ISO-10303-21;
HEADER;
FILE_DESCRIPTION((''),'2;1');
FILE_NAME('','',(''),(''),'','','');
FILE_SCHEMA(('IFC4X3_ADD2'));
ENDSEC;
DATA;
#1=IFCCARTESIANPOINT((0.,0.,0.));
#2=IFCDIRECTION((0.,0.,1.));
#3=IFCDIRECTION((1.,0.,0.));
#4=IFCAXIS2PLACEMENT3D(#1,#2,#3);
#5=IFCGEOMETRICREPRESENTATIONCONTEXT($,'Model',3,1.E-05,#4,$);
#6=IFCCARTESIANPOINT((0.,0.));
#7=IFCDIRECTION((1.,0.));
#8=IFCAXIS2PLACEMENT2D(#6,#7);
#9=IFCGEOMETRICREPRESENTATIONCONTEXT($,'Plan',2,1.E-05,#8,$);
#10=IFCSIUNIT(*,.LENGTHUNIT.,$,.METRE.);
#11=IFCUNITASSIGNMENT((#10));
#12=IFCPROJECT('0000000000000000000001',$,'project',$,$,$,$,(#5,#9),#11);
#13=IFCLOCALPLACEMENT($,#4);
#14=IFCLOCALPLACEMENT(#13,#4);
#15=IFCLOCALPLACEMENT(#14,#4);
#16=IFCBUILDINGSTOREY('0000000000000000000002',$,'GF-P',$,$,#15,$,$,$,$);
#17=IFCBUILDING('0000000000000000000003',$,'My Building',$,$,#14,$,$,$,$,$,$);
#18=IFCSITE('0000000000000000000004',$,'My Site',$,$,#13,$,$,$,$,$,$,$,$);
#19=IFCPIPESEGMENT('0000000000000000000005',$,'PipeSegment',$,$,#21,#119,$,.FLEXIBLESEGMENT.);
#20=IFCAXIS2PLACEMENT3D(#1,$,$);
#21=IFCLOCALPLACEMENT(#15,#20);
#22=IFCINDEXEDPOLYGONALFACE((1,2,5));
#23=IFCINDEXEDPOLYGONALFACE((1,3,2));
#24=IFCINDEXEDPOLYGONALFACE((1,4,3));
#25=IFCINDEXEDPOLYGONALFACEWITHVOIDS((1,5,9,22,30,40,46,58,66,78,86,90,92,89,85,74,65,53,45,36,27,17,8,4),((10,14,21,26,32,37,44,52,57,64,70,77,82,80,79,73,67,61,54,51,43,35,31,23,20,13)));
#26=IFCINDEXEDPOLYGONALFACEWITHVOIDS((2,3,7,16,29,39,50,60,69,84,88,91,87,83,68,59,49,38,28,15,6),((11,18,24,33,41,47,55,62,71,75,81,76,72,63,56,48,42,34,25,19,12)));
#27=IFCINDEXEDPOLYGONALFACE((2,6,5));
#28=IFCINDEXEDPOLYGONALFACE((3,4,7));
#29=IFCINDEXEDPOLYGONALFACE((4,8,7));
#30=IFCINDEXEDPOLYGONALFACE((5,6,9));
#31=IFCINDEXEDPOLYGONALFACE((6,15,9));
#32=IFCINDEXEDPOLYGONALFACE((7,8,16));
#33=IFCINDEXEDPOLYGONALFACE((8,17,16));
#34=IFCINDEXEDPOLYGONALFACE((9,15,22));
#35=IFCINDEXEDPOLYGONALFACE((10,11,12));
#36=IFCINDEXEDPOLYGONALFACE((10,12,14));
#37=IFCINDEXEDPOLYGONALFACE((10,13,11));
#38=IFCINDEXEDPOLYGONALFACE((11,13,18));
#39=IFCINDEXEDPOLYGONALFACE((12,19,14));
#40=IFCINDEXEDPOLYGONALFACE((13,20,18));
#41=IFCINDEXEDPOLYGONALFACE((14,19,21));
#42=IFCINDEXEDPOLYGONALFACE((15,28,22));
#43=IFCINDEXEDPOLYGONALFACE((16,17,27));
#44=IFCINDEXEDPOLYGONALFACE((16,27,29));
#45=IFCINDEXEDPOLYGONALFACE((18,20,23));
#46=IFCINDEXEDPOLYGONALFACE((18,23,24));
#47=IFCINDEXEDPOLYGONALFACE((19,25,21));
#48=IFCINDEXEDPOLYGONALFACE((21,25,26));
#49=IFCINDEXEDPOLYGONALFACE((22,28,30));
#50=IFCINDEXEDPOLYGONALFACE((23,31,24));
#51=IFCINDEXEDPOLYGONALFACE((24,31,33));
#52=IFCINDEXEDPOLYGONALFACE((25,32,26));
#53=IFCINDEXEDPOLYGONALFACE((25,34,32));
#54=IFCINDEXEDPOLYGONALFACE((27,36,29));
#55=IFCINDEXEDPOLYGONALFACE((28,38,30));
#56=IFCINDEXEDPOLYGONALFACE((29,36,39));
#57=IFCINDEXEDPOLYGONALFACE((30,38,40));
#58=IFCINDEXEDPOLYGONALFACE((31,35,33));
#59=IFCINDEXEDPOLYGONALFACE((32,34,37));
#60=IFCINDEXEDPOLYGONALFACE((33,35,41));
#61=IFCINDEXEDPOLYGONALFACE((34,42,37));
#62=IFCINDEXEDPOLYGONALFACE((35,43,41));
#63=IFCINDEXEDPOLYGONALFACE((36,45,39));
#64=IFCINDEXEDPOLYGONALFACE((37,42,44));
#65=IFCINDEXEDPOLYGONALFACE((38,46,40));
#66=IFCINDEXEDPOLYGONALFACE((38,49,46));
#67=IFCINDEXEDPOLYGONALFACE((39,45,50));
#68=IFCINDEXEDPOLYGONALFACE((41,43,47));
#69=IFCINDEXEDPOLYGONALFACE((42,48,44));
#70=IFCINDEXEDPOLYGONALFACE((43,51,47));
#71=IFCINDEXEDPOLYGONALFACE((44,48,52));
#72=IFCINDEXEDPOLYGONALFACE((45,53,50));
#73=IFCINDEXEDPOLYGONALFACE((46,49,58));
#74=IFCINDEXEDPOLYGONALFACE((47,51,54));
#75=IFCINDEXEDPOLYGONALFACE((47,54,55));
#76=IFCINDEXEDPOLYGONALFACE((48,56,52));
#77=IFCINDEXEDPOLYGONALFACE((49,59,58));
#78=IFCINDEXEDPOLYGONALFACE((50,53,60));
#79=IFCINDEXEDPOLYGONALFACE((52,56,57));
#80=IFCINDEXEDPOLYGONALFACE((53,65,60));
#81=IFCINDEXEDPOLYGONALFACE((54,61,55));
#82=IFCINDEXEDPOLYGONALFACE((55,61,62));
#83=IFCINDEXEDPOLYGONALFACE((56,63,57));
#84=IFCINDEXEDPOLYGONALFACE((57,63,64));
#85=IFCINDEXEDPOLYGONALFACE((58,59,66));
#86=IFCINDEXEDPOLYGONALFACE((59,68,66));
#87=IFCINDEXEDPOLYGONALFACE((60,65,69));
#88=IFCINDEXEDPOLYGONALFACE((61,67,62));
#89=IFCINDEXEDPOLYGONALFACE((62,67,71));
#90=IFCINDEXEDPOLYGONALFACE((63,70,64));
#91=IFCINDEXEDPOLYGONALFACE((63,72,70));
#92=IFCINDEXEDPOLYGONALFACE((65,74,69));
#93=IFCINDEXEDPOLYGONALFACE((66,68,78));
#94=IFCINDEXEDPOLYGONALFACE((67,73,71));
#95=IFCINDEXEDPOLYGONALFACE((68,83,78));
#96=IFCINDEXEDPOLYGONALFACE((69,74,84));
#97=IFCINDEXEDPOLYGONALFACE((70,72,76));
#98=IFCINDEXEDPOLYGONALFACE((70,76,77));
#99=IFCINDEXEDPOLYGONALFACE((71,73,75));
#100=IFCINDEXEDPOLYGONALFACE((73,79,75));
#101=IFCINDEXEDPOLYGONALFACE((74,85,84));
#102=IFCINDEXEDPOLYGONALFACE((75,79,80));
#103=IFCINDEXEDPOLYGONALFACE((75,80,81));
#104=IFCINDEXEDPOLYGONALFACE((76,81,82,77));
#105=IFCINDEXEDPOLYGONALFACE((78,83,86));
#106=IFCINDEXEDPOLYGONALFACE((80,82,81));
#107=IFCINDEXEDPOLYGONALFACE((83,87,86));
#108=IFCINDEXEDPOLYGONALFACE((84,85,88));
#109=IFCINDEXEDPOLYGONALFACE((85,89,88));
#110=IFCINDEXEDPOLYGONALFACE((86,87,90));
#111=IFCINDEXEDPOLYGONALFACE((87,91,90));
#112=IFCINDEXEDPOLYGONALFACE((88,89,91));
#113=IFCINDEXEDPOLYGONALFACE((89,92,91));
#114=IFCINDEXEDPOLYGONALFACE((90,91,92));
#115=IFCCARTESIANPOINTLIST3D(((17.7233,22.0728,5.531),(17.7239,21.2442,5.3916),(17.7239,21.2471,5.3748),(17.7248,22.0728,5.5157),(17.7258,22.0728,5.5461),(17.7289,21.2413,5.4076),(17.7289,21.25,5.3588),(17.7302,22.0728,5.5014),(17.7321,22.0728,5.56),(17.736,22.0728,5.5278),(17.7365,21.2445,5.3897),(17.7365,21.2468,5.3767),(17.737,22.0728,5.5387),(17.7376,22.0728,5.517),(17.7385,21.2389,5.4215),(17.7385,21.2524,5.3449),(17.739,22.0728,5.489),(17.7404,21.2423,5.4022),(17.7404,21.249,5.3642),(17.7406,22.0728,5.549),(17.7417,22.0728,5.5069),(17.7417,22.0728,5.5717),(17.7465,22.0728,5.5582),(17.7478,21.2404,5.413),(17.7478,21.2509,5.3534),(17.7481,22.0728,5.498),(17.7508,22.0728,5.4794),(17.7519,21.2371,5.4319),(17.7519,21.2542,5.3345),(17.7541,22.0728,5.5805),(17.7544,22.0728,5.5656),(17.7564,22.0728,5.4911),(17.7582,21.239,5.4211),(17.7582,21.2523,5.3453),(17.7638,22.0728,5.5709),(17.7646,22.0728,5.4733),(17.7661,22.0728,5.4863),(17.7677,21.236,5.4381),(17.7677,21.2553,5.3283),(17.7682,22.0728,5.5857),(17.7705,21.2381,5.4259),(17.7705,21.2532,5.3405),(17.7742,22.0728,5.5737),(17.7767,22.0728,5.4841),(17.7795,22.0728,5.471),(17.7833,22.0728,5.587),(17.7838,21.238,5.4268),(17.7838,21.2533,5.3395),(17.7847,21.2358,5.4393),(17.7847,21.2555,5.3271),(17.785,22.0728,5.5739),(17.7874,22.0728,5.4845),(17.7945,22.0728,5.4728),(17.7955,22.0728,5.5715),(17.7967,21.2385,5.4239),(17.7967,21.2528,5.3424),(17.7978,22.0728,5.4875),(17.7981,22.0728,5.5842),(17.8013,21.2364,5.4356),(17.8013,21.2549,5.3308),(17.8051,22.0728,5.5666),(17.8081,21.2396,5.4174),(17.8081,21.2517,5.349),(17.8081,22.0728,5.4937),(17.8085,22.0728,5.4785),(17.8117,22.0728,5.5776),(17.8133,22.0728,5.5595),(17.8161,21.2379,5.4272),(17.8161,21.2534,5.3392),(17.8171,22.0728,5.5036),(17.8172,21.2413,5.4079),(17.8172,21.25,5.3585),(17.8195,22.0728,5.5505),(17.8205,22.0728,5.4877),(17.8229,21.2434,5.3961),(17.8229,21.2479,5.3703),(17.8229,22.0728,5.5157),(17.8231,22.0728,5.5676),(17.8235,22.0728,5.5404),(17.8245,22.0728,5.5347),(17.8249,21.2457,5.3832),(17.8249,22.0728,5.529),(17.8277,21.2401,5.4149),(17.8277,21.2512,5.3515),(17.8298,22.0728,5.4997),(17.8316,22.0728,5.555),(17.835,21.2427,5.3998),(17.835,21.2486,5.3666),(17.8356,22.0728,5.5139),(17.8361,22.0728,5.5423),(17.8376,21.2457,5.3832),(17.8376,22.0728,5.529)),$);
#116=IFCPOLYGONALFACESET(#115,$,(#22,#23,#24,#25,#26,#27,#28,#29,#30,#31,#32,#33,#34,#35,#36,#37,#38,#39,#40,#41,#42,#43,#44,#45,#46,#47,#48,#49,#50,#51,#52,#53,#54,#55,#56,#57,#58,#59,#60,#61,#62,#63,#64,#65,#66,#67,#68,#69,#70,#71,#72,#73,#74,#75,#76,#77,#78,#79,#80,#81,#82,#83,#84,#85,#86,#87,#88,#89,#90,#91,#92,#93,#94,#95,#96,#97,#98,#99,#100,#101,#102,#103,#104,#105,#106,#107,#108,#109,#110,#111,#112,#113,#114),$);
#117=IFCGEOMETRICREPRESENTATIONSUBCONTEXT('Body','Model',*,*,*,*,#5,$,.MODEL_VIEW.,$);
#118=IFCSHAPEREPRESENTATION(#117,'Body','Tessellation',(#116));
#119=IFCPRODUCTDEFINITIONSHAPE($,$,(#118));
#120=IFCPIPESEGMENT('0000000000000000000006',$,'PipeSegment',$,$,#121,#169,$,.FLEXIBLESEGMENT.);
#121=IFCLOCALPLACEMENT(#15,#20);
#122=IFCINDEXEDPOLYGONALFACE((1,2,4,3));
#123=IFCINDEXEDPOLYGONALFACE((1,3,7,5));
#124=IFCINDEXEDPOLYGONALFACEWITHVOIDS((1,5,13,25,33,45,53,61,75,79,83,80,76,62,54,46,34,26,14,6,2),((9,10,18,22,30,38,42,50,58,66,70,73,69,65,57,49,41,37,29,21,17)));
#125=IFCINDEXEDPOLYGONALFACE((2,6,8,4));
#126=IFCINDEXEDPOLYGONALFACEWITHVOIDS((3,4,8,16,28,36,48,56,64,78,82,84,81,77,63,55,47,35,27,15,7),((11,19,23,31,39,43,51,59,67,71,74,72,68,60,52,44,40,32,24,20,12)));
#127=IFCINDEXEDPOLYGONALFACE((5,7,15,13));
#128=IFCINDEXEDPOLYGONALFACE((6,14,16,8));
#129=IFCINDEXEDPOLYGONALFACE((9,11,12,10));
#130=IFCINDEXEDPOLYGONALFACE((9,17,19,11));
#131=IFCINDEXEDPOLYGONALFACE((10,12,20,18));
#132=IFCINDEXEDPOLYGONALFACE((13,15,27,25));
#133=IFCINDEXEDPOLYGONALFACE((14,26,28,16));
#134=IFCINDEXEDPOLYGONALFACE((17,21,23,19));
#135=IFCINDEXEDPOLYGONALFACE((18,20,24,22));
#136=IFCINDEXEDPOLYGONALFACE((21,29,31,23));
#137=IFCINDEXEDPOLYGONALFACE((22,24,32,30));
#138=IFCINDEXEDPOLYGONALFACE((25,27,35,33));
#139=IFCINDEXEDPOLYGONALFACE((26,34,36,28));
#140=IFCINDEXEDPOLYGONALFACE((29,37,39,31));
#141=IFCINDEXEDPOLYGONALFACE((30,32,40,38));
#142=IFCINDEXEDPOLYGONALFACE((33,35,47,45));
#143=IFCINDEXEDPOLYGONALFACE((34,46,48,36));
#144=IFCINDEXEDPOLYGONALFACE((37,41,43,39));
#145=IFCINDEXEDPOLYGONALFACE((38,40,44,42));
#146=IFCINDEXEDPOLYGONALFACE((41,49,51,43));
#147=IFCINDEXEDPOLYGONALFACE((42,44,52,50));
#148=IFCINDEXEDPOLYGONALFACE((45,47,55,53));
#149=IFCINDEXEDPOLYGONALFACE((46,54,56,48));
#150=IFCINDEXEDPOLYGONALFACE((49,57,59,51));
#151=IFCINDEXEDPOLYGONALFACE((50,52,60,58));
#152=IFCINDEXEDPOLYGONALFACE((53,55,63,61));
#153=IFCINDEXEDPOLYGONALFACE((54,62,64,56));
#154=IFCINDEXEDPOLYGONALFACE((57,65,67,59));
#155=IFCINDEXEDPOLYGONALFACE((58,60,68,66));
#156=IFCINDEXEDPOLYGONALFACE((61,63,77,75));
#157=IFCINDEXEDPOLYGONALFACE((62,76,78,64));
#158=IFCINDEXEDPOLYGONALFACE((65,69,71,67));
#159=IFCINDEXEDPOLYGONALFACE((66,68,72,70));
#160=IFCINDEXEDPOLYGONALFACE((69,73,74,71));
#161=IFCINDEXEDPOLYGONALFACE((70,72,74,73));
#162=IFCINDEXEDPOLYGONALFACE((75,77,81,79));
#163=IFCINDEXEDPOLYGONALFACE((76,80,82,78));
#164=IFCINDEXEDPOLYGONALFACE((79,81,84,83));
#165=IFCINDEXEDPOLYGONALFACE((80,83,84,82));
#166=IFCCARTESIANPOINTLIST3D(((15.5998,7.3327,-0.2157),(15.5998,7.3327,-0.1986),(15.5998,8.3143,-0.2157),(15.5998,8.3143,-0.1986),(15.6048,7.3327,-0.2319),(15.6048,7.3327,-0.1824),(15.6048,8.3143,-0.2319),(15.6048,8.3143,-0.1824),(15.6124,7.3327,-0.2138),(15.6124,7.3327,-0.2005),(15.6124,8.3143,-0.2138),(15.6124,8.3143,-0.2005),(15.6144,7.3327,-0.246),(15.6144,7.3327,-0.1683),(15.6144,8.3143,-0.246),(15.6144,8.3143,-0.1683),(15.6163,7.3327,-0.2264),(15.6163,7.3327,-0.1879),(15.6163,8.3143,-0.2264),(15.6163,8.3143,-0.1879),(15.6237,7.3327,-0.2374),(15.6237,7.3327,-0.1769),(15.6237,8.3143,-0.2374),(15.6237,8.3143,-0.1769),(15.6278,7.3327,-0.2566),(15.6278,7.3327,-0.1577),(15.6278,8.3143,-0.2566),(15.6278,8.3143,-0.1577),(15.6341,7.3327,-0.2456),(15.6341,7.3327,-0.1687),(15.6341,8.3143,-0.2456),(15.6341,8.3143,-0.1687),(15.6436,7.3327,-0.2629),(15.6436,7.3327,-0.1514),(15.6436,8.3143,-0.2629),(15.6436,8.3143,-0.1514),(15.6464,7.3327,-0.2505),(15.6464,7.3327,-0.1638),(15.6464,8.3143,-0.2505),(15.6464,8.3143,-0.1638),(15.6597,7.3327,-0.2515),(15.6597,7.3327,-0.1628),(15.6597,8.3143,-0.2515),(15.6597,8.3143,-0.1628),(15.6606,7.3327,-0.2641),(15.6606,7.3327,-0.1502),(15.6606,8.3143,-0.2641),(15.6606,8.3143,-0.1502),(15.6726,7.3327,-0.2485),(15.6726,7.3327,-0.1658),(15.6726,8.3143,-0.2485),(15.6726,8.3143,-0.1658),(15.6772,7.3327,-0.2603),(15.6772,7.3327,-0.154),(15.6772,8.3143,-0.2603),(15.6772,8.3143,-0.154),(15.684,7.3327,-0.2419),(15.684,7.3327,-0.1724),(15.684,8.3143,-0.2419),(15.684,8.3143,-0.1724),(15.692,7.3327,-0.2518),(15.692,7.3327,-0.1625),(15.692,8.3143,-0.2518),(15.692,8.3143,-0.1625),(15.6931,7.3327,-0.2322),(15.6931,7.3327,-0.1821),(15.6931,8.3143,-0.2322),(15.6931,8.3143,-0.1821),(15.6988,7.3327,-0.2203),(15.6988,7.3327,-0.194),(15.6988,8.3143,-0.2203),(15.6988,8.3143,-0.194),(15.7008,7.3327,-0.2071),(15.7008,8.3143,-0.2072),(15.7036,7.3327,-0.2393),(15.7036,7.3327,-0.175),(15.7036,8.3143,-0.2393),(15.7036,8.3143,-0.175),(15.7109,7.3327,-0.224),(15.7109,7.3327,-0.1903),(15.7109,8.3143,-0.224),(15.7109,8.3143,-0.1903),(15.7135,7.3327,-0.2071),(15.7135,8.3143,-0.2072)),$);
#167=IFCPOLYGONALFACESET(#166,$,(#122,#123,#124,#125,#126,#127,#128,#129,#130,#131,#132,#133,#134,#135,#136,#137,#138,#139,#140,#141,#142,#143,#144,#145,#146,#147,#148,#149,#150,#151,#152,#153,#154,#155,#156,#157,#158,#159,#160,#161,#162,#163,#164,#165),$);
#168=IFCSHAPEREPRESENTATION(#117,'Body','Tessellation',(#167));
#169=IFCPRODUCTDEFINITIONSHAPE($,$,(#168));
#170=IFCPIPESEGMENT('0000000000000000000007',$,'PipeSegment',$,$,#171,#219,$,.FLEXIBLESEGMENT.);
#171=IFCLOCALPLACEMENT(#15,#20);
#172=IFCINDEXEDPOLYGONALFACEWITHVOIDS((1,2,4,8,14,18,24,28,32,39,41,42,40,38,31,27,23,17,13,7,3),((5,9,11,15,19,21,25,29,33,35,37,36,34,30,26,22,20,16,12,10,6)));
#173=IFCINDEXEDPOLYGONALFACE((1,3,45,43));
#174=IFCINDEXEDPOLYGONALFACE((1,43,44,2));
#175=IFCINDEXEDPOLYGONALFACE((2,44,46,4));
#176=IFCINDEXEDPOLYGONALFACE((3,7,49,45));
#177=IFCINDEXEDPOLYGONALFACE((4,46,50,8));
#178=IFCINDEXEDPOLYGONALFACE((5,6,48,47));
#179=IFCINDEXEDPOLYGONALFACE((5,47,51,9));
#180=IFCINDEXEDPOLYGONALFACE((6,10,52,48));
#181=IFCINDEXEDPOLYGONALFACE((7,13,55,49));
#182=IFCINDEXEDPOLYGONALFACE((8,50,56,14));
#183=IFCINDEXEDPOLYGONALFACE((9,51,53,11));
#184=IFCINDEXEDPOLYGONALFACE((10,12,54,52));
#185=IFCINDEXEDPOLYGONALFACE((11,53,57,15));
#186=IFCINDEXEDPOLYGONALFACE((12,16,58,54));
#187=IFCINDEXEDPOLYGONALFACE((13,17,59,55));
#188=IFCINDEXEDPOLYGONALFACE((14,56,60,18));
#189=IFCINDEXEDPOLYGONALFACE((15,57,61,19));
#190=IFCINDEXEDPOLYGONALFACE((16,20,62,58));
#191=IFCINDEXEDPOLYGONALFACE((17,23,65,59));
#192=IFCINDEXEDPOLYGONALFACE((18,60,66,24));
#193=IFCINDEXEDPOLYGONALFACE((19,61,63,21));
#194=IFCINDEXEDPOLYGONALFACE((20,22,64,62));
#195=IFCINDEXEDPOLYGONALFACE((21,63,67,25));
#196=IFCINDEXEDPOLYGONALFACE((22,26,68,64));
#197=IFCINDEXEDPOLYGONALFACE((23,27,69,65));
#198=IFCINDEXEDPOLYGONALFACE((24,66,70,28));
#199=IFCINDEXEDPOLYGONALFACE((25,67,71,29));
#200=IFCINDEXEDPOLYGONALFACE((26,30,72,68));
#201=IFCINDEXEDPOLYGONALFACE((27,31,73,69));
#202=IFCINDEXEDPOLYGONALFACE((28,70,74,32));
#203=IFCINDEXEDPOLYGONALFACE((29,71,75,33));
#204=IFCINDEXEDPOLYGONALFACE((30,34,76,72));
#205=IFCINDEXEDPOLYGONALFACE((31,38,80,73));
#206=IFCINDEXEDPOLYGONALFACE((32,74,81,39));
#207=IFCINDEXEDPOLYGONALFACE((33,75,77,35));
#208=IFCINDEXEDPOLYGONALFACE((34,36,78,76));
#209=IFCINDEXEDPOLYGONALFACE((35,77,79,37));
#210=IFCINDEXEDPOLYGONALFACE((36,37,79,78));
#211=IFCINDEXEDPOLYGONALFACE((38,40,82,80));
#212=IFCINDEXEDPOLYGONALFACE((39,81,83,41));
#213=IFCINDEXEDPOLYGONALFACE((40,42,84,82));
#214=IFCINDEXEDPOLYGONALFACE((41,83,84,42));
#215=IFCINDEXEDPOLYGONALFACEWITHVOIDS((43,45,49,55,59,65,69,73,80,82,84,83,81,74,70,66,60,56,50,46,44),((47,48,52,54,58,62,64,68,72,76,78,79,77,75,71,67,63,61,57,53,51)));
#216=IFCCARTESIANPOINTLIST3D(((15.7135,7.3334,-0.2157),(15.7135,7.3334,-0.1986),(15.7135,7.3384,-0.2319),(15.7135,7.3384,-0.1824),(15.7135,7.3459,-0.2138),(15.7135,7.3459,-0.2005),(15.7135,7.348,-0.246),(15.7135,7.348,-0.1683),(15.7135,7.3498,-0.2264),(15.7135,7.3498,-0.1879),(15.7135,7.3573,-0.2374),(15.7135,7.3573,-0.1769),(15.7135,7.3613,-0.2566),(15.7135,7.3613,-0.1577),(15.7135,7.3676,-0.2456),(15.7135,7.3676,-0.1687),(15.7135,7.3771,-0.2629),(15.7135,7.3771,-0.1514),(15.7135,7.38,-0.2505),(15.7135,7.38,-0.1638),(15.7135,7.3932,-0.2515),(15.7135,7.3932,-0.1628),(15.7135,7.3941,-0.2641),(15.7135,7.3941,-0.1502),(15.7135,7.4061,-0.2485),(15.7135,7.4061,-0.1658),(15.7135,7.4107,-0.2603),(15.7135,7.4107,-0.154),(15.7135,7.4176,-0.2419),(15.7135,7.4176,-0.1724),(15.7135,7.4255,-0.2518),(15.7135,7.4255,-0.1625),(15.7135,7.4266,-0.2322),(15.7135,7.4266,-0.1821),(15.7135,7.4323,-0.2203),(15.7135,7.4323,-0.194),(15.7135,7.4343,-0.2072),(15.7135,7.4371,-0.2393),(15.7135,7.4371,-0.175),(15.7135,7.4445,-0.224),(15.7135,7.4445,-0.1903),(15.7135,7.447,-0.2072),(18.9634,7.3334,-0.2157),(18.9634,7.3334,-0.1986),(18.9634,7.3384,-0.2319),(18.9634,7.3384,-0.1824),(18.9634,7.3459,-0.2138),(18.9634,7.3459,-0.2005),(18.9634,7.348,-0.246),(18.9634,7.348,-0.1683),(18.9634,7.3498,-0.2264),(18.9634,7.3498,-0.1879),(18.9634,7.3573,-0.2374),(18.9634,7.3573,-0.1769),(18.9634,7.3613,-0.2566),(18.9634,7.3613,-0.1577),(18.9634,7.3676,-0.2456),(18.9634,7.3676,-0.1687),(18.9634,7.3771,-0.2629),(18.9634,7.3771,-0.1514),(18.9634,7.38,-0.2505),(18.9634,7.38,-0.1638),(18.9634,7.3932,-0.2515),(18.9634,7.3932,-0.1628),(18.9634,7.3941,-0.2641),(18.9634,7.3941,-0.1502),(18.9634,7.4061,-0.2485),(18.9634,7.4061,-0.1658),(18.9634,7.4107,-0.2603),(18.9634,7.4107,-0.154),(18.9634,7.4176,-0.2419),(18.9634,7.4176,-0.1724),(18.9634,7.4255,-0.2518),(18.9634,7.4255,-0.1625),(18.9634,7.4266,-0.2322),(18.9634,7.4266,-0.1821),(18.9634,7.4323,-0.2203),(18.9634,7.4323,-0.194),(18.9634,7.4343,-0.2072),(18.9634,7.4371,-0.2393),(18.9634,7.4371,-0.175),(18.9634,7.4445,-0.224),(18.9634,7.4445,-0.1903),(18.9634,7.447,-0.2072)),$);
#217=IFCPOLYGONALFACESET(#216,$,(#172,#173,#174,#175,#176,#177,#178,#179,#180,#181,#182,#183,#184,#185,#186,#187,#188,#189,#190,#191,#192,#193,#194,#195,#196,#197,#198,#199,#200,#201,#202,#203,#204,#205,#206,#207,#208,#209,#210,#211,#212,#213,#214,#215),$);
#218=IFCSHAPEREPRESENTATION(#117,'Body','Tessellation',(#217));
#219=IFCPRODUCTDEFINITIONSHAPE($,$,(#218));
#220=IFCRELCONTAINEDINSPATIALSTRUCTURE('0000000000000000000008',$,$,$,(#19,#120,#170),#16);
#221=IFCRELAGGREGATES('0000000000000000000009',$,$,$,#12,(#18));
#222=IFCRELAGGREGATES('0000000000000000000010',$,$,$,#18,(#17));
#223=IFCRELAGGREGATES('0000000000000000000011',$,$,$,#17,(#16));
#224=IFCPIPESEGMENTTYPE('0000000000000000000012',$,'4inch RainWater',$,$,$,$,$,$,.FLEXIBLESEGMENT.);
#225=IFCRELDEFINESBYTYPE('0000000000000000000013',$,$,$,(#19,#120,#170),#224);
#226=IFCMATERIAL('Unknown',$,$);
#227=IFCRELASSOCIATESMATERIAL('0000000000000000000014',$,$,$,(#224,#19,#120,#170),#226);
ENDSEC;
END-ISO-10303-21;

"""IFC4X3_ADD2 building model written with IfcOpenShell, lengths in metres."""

from ifc_helpers import new_model, si_unit, frame, origin_with_axes, origin_2d_with_axis, place, context, subcontext, project, spatial, hollow_circle, extrude, clip, halfspace, material, material_profile, profile_set, profile_usage, type_object, element, save


model = new_model("IFC4X3_ADD2")

# Units and contexts
model_context = context("Model", 3, precision=1e-05, world=origin_with_axes())
plan_context = context("Plan", 2, precision=1e-05, world=origin_2d_with_axis())
body_context = subcontext(model_context, "Body", "Model", "MODEL_VIEW")
ifc_project = project(units=[si_unit("LENGTHUNIT", "METRE")], contexts=[model_context, plan_context])

# Site, building, storey
site_placement = place(None, origin_with_axes())
site = spatial("IfcSite", under=ifc_project, at=site_placement, Name="My Site")
building_placement = place(site_placement, origin_with_axes())
building = spatial("IfcBuilding", under=site, at=building_placement, Name="My Building")
storey_placement = place(building_placement, origin_with_axes())
storey = spatial("IfcBuildingStorey", under=building, at=storey_placement, Name="GF-P")

# Shared definitions
ifc_material_1 = material(Name="Unknown")

# Pipe segments
ifc_material_profile_1 = material_profile(ifc_material_1, hollow_circle(Radius=0.0571, WallThickness=0.0127))
ifc_profile_set_1 = profile_set([ifc_material_profile_1], Name="rainwater")
pipe_segment_type_1 = type_object("IfcPipeSegmentType", Name="4inch RainWater", PredefinedType="FLEXIBLESEGMENT", material=ifc_profile_set_1)
ifc_profile_usage_1 = profile_usage(ifc_profile_set_1)
pipe_segment_1_placement = place(storey_placement, frame((17.7804, 21.2457, 5.3832), z_axis=(0.0, 0.984808, 0.173648), x_axis=(1.0, 0.0, 0.0)))
element("IfcPipeSegment", 1, at=pipe_segment_1_placement, inside=storey, type_object=pipe_segment_type_1, material=ifc_profile_usage_1, Name="PipeSegment", PredefinedType="FLEXIBLESEGMENT", context=body_context, shape_type="Clipping", body=[
    clip(extrude(hollow_circle(Radius=0.0571, WallThickness=0.0127), origin_with_axes(), (0.0, 0.0, 1.0), 0.9542), halfspace(frame((0.0, 0.1595, 0.8117), z_axis=(0.0, 0.173648, 0.984808), x_axis=(1.0, 0.000002, 0.0)), False)),
])
ifc_profile_usage_2 = profile_usage(ifc_profile_set_1)
pipe_segment_2_placement = place(storey_placement, frame((15.6563, 8.3143, -0.2072), z_axis=(0.0, -1.0, 0.0), x_axis=(1.0, 0.0, 0.0)))
element("IfcPipeSegment", 2, at=pipe_segment_2_placement, inside=storey, type_object=pipe_segment_type_1, material=ifc_profile_usage_2, Name="PipeSegment", PredefinedType="FLEXIBLESEGMENT", context=body_context, shape_type="SweptSolid", body=[
    extrude(hollow_circle(Radius=0.0571, WallThickness=0.0127), origin_with_axes(), (0.0, 0.0, 1.0), 0.9815),
])
ifc_profile_usage_3 = profile_usage(ifc_profile_set_1)
pipe_segment_3_placement = place(storey_placement, frame((15.7135, 7.3899, -0.2072), z_axis=(1.0, 0.0, 0.0), x_axis=(0.0, 1.0, 0.0)))
element("IfcPipeSegment", 3, at=pipe_segment_3_placement, inside=storey, type_object=pipe_segment_type_1, material=ifc_profile_usage_3, Name="PipeSegment", PredefinedType="FLEXIBLESEGMENT", context=body_context, shape_type="SweptSolid", body=[
    extrude(hollow_circle(Radius=0.0571, WallThickness=0.0127), origin_with_axes(), (0.0, 0.0, 1.0), 3.2499),
])

save(model, "model.ifc")
